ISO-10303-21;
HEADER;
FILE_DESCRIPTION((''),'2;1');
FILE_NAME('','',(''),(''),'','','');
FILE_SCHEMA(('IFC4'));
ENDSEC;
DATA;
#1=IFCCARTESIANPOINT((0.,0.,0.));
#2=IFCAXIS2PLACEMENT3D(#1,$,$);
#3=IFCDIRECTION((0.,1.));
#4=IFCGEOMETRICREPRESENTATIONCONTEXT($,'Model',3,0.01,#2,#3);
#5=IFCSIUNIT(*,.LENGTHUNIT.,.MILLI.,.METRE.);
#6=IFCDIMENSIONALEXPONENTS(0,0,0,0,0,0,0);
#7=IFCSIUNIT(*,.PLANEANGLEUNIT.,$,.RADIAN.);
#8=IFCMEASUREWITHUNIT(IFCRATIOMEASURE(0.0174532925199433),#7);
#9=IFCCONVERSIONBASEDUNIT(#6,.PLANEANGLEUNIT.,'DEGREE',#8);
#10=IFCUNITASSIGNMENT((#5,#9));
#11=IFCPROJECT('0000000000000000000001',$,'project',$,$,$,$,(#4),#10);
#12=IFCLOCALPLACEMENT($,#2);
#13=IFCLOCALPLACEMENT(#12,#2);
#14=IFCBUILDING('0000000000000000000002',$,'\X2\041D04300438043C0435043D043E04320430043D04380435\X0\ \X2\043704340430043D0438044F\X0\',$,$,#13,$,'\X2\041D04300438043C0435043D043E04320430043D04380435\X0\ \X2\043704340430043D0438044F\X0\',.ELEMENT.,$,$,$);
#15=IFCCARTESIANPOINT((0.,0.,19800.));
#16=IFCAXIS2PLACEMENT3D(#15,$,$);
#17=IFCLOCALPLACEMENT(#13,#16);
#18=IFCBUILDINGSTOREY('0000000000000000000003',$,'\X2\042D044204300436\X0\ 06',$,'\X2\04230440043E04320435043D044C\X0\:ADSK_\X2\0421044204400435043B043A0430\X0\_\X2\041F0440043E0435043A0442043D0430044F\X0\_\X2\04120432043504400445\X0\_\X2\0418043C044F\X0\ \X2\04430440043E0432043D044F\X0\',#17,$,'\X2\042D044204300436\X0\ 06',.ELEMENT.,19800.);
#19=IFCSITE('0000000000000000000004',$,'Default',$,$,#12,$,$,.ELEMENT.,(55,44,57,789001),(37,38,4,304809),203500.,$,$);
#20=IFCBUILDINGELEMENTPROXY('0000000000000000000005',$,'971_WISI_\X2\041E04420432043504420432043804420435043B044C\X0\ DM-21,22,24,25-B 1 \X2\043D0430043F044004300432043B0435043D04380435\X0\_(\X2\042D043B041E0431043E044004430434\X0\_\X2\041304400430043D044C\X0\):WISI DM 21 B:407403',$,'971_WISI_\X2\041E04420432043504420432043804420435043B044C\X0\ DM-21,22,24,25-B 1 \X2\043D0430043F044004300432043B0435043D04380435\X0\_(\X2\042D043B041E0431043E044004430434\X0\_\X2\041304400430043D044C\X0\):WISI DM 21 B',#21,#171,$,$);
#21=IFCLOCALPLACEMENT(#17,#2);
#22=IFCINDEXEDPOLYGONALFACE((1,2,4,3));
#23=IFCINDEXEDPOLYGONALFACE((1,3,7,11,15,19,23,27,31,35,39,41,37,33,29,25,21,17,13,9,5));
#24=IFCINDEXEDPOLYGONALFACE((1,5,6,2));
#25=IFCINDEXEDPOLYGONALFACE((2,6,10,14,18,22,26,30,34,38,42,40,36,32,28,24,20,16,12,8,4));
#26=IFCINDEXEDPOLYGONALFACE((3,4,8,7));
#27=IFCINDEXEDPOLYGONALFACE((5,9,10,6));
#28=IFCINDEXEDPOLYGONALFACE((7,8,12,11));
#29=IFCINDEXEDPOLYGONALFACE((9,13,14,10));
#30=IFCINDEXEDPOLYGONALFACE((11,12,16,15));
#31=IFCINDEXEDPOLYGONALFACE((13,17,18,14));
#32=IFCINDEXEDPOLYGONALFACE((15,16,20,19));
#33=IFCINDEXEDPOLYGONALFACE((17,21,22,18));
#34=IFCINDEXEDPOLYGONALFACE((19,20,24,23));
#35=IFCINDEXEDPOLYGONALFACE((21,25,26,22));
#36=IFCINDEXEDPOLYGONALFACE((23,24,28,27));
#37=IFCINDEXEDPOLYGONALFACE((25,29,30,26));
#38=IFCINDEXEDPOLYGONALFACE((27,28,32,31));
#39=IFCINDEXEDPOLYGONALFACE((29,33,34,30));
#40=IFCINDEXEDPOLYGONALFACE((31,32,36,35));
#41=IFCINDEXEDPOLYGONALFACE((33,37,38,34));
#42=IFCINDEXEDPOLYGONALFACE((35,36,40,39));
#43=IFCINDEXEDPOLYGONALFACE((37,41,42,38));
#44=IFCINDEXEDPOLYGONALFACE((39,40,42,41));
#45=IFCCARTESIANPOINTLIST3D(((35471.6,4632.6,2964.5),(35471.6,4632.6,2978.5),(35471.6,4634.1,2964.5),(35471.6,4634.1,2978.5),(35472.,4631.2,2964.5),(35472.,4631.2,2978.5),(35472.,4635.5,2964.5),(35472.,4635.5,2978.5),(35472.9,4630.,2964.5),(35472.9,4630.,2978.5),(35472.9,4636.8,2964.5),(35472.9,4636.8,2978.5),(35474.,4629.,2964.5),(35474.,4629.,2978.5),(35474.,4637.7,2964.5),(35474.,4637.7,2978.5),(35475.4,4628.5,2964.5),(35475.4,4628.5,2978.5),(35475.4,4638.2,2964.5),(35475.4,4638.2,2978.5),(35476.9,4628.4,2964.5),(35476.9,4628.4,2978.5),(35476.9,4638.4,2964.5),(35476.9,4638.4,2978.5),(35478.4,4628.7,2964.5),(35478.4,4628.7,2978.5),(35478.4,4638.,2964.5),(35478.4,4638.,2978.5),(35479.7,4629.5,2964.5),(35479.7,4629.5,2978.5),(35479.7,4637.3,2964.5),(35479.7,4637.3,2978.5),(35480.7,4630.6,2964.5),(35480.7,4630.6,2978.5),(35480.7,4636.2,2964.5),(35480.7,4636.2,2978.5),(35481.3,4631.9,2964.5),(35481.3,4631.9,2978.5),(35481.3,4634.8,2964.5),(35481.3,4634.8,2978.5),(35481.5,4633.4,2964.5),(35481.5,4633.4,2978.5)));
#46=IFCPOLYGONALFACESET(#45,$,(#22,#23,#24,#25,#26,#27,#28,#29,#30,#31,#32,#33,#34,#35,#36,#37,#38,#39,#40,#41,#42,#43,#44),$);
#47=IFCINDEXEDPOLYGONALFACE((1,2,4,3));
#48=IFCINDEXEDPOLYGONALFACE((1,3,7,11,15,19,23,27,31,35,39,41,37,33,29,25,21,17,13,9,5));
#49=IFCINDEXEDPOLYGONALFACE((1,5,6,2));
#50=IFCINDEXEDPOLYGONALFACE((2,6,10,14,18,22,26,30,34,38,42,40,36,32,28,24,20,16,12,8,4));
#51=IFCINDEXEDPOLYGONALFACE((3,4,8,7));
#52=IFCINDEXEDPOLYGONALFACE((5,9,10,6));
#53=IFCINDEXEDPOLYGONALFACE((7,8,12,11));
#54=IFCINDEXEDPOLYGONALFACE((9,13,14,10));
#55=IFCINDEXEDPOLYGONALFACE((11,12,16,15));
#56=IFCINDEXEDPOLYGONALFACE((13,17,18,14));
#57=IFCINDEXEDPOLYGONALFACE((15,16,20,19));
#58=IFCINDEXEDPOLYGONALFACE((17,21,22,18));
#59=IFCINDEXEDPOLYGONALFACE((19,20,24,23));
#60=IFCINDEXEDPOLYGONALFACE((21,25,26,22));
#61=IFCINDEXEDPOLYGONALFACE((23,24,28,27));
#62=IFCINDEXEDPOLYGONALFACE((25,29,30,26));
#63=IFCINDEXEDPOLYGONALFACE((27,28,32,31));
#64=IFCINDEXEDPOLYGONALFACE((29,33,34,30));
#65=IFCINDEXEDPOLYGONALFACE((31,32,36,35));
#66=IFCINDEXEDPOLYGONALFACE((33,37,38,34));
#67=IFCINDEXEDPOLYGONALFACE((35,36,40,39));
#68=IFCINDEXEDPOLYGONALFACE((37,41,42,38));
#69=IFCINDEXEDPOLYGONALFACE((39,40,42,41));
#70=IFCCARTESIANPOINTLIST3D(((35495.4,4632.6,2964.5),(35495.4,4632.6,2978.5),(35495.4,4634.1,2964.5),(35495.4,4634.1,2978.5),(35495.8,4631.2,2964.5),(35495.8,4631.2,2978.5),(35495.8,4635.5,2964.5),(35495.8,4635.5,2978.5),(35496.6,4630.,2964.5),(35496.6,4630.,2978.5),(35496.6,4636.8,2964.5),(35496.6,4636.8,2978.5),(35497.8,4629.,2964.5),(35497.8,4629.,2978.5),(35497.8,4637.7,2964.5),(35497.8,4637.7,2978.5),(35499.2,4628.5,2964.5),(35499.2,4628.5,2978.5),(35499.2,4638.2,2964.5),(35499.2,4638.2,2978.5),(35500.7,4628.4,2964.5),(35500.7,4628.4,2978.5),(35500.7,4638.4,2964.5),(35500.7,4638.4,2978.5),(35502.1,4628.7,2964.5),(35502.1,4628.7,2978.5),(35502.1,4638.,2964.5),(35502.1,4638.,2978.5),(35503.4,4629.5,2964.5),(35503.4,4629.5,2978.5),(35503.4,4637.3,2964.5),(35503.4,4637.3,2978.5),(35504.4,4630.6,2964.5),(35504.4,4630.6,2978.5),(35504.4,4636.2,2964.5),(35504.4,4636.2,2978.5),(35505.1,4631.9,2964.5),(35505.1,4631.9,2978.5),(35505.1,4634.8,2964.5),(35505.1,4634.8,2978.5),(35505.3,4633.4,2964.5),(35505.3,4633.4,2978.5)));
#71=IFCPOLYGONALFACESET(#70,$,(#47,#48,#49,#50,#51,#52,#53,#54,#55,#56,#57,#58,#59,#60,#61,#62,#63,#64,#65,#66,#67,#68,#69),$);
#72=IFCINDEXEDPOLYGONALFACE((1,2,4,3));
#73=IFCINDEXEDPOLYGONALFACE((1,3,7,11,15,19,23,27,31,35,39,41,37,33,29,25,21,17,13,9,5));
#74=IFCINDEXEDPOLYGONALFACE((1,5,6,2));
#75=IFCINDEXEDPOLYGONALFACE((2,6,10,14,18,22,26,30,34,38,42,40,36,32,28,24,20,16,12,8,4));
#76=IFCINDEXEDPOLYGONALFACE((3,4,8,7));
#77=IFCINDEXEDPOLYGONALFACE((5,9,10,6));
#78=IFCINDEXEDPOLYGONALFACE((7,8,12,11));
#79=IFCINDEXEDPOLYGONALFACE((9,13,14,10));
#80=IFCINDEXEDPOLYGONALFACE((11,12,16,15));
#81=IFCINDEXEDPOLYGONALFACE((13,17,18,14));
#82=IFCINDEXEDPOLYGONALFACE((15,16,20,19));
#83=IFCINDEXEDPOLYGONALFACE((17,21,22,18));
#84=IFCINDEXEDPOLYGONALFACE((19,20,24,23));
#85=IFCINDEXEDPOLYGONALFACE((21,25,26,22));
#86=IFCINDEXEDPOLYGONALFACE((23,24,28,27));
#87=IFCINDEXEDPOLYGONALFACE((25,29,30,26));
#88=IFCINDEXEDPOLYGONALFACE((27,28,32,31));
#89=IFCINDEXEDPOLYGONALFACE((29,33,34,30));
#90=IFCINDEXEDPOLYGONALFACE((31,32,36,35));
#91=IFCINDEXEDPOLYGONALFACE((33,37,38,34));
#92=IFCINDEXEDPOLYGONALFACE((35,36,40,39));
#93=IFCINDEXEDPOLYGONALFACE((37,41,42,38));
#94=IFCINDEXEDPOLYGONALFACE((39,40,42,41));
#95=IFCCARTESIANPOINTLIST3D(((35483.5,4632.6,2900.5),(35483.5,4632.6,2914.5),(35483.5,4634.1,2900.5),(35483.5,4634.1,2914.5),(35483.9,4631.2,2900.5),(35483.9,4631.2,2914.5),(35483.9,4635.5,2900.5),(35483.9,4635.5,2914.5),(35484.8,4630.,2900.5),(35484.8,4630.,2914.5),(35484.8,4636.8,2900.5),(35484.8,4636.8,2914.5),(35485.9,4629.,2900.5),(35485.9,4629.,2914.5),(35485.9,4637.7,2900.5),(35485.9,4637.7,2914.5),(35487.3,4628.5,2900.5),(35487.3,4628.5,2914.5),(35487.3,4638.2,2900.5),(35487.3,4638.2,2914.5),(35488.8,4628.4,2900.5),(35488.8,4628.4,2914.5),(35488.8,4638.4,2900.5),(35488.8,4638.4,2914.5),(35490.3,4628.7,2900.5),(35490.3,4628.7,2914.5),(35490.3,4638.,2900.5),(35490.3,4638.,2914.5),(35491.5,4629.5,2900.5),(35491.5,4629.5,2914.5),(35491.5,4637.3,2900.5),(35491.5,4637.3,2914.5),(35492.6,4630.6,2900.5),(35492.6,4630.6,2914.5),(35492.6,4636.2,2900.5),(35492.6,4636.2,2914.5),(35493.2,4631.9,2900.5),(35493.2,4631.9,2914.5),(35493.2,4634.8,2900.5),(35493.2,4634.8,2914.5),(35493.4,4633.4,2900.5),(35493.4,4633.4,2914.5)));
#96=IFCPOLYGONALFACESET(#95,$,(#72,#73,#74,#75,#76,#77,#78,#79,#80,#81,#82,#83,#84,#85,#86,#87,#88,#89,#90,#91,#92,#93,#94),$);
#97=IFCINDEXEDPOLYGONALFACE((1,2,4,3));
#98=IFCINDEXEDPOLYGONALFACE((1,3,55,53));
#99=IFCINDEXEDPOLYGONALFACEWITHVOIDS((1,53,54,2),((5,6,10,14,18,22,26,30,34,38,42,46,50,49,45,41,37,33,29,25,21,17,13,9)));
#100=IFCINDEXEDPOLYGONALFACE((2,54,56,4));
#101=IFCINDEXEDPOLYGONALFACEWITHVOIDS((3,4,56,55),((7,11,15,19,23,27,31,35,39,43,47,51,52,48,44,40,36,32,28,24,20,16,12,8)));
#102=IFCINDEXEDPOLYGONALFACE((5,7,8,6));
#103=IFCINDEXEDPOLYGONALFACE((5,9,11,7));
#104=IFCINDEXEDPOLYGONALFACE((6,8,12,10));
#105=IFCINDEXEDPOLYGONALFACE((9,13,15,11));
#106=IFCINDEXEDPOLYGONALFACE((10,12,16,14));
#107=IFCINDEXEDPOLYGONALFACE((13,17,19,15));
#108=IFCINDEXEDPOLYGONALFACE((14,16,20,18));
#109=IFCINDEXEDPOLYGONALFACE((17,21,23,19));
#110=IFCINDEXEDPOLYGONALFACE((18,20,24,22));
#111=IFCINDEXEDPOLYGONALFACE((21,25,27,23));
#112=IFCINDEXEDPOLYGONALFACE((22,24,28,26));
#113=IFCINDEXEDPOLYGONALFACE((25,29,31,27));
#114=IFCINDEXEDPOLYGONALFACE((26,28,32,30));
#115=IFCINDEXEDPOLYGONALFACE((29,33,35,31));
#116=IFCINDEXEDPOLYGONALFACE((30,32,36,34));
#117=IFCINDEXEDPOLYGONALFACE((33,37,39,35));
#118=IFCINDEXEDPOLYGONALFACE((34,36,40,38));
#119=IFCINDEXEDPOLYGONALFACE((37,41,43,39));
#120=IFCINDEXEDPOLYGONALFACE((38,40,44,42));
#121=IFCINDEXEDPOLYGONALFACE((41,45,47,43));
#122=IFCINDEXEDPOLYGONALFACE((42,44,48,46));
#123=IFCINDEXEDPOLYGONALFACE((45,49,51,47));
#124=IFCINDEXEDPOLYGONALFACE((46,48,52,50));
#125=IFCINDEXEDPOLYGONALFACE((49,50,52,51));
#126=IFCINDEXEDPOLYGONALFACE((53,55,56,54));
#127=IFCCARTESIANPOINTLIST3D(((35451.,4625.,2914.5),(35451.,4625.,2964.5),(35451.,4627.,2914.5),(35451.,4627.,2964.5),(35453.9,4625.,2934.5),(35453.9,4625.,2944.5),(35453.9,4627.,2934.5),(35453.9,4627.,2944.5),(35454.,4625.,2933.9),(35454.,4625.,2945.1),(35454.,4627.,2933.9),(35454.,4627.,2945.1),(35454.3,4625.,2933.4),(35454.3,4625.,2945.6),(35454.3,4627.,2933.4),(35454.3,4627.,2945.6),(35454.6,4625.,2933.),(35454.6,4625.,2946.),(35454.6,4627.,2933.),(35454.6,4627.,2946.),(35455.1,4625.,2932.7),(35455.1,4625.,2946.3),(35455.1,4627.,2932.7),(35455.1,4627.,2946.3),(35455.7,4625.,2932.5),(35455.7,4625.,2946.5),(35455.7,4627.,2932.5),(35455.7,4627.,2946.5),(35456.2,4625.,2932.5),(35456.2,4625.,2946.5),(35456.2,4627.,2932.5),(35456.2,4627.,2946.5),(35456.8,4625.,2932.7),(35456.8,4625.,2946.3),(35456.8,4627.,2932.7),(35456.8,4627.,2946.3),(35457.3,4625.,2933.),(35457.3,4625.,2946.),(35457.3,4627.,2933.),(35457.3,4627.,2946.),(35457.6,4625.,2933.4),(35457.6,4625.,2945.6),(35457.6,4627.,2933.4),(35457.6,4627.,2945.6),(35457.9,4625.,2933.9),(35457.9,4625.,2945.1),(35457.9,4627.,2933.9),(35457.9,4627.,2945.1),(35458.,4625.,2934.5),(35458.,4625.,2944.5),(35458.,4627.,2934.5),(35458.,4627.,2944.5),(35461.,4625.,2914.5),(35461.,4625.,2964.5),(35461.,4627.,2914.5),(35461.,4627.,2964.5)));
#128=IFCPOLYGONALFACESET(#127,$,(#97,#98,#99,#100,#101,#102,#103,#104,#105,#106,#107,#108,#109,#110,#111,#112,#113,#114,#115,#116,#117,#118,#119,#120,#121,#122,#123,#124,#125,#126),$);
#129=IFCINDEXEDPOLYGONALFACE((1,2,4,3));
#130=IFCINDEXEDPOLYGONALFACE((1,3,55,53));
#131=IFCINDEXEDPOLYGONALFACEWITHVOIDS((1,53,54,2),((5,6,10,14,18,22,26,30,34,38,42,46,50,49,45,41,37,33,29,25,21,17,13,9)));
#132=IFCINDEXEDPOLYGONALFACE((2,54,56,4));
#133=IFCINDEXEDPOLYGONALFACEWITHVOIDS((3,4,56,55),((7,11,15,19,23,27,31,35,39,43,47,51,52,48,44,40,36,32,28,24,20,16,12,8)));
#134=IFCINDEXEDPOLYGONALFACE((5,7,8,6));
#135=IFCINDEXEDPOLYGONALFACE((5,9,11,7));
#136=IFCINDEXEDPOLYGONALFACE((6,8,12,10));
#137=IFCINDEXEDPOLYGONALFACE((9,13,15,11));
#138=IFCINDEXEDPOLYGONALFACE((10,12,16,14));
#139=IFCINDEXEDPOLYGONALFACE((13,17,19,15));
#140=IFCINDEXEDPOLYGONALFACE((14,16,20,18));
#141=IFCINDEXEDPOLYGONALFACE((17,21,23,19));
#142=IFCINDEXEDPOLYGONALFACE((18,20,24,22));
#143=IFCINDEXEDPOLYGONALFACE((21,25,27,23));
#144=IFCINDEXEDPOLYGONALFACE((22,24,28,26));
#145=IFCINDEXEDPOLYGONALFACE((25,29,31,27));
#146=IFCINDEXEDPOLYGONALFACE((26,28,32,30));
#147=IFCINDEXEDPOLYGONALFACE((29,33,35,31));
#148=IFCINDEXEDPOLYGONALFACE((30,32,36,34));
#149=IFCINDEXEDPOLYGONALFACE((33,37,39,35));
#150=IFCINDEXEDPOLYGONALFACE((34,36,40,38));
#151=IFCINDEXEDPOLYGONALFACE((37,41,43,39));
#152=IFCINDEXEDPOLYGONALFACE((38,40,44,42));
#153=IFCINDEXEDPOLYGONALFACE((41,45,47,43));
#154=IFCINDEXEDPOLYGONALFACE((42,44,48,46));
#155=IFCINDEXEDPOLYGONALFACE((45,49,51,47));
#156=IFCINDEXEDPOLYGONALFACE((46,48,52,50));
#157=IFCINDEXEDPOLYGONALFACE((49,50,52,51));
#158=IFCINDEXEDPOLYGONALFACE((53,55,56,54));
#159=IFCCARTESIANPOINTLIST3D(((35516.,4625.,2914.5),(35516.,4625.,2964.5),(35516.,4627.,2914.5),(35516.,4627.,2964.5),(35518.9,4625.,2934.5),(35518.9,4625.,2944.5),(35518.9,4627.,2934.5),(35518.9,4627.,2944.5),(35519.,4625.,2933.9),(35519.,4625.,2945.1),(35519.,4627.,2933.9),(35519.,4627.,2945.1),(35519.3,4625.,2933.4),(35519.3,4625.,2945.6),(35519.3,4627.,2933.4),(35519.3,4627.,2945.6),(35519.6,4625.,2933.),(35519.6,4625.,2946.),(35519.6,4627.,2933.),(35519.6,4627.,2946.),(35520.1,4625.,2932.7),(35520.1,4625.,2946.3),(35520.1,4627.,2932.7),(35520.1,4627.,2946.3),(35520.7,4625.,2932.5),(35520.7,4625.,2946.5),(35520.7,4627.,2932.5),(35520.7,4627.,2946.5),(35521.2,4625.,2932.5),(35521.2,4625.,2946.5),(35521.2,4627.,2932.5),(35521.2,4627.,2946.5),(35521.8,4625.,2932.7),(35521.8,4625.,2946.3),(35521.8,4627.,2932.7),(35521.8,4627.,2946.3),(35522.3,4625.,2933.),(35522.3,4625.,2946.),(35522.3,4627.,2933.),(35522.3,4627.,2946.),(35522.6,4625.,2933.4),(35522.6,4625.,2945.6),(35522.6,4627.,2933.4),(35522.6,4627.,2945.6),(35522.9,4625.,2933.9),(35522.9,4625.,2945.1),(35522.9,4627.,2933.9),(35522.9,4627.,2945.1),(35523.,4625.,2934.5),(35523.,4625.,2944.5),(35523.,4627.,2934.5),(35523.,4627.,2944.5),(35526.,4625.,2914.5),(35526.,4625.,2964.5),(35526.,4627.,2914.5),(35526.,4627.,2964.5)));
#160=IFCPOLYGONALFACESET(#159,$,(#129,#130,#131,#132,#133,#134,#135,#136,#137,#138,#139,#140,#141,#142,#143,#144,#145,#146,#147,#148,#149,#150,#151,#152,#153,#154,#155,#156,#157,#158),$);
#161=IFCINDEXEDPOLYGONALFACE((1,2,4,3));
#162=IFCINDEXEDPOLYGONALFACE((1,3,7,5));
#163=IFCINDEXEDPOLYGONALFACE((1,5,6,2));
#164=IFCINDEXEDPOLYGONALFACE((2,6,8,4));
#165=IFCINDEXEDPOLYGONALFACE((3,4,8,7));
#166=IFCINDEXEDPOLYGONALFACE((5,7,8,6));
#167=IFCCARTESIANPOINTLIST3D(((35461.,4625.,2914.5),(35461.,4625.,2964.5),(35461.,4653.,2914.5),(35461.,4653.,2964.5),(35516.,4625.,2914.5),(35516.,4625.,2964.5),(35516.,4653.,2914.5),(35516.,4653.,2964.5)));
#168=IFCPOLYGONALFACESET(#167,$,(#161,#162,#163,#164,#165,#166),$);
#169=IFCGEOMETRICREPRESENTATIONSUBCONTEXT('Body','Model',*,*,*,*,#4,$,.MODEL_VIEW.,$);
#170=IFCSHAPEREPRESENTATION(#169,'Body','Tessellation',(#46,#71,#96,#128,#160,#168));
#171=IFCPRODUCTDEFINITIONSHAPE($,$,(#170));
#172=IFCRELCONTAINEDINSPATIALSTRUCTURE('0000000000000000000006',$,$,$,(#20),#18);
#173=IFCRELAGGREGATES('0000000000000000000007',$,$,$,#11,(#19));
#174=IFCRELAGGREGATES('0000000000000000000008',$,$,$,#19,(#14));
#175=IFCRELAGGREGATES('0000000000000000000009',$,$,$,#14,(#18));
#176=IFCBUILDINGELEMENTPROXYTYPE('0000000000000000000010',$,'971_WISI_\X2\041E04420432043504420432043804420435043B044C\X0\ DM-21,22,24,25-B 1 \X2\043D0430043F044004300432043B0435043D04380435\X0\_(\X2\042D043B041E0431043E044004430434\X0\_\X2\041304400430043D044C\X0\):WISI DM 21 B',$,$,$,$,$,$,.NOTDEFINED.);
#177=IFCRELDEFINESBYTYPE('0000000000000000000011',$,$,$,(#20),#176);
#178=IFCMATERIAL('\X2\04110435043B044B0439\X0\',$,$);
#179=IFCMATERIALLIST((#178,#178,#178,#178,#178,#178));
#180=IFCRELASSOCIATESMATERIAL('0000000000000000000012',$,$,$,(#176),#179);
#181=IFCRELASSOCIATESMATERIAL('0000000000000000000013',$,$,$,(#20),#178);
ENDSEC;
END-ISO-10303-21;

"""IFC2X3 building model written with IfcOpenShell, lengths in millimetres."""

from ifc_helpers import new_model, entity, si_unit, converted_unit, direction, frame, frame_2d, origin, place, context, subcontext, project, spatial, polyline, circle_curve, parameter, trimmed, segment, composite_curve, rectangle, circle, outline, extrude, source, transform, mapped, material, material_list, type_object, type_shapes, element, save


model = new_model("IFC2X3")

# Units and contexts
model_context = context("Model", 3, precision=0.01, world=origin(), true_north=direction((0.0, 1.0)))
body_context = subcontext(model_context, "Body", "Model", "MODEL_VIEW")
ifc_project = project(units=[si_unit("LENGTHUNIT", "METRE", prefix="MILLI"), converted_unit("PLANEANGLEUNIT", "DEGREE", entity("IfcRatioMeasure", 0.0174532925199433), si_unit("PLANEANGLEUNIT", "RADIAN"), dimensions=[0, 0, 0, 0, 0, 0, 0])], contexts=[model_context])

# Site, building, storey
site_placement = place(None, frame((0.0, 0.0, 0.0)))
site = spatial("IfcSite", under=ifc_project, at=site_placement, Name="Default", CompositionType="ELEMENT", RefLatitude=(55, 44, 57, 789001), RefLongitude=(37, 38, 4, 304809), RefElevation=203500.0)
building_placement = place(site_placement, origin())
building = spatial("IfcBuilding", under=site, at=building_placement, Name="Наименование здания", LongName="Наименование здания", CompositionType="ELEMENT")
storey_placement = place(building_placement, frame((0.0, 0.0, 19800.0)))
storey = spatial("IfcBuildingStorey", under=building, at=storey_placement, Name="Этаж 06", ObjectType="Уровень:ADSK_Стрелка_Проектная_Вверх_Имя уровня", LongName="Этаж 06", CompositionType="ELEMENT", Elevation=19800.0)

# Building element proxy
ifc_material_1 = material(Name="Белый")
ifc_material_list_1 = material_list([ifc_material_1, ifc_material_1, ifc_material_1, ifc_material_1, ifc_material_1, ifc_material_1])
building_element_proxy_type_1 = type_object("IfcBuildingElementProxyType", Name="971_WISI_Ответвитель DM-21,22,24,25-B 1 направление_(ЭлОборуд_Грань):WISI DM 21 B", PredefinedType="NOTDEFINED", material=ifc_material_list_1)
shared_shape_1 = source(origin(), body_context, "Body", "SweptSolid", [
    extrude(circle(Radius=5.0, at=frame_2d((0.0, 0.0), x_axis=(1.0, 0.0))), frame((11.9, 25.0, 8.4), z_axis=(0.0, 1.0, 0.0), x_axis=(-1.0, 0.0, 0.0)), (0.0, 0.0, 1.0), 14.0),
    extrude(circle(Radius=5.0, at=frame_2d((0.0, 0.0), x_axis=(1.0, 0.0))), frame((-11.8, 25.0, 8.4), z_axis=(0.0, 1.0, 0.0), x_axis=(-1.0, 0.0, 0.0)), (0.0, 0.0, 1.0), 14.0),
    extrude(circle(Radius=5.0, at=frame_2d((0.0, 0.0), x_axis=(1.0, 0.0))), frame((0.0, -39.0, 8.4), z_axis=(0.0, 1.0, 0.0), x_axis=(-1.0, 0.0, 0.0)), (0.0, 0.0, 1.0), 14.0),
    extrude(outline(polyline([(-5.0, -25.0), (5.0, -25.0), (5.0, 25.0), (-5.0, 25.0), (-5.0, -25.0)]), holes=[composite_curve([segment(polyline([(2.0, 5.0), (2.0, -5.0)]), True, "CONTINUOUS"), segment(trimmed(circle_curve(frame_2d((0.0, -5.0), x_axis=(-1.0, 0.0)), 2.0), [parameter(0.0)], [parameter(180.0)], True, "PARAMETER"), False, "CONTINUOUS"), segment(polyline([(-2.0, -5.0), (-2.0, 5.0)]), True, "CONTINUOUS"), segment(trimmed(circle_curve(frame_2d((0.0, 5.0), x_axis=(-1.0, 0.0)), 2.0), [parameter(180.0)], [parameter(0.0)], True, "PARAMETER"), False, "CONTINUOUS")], self_intersect=False)]), frame((32.5, 0.0, 0.0), z_axis=(0.0, 0.0, 1.0), x_axis=(-1.0, 0.0, 0.0)), (0.0, 0.0, 1.0), 2.0),
    extrude(outline(polyline([(-5.0, -25.0), (5.0, -25.0), (5.0, 25.0), (-5.0, 25.0), (-5.0, -25.0)]), holes=[composite_curve([segment(polyline([(-2.0, -5.0), (-2.0, 5.0)]), True, "CONTINUOUS"), segment(trimmed(circle_curve(frame_2d((0.0, 5.0), x_axis=(-1.0, 0.0)), 2.0), [parameter(180.0)], [parameter(0.0)], True, "PARAMETER"), False, "CONTINUOUS"), segment(polyline([(2.0, 5.0), (2.0, -5.0)]), True, "CONTINUOUS"), segment(trimmed(circle_curve(frame_2d((0.0, -5.0), x_axis=(-1.0, 0.0)), 2.0), [parameter(0.0)], [parameter(180.0)], True, "PARAMETER"), False, "CONTINUOUS")], self_intersect=False)]), frame((-32.5, 0.0, 0.0), z_axis=(0.0, 0.0, 1.0), x_axis=(-1.0, 0.0, 0.0)), (0.0, 0.0, 1.0), 2.0),
    extrude(rectangle(XDim=55.0, YDim=50.0, at=frame_2d((0.0, 0.0), x_axis=(1.0, 0.0))), frame((0.0, 0.0, 0.0), z_axis=(0.0, 0.0, 1.0), x_axis=(-1.0, 0.0, 0.0)), (0.0, 0.0, 1.0), 28.0),
])
type_shapes(building_element_proxy_type_1, [shared_shape_1])
for number, where, z_axis, x_axis, name in (
    (1, (35488.5, 4625.0, 2939.5), (0.0, 1.0, 0.0), (-1.0, 0.0, 0.0), "971_WISI_Ответвитель DM-21,22,24,25-B 1 направление_(ЭлОборуд_Грань):WISI DM 21 B:407403"),
):
    element("IfcBuildingElementProxy", number, at=place(storey_placement, frame(where, z_axis=z_axis, x_axis=x_axis)), inside=storey, type_object=building_element_proxy_type_1, material=ifc_material_1, Name=name, ObjectType="971_WISI_Ответвитель DM-21,22,24,25-B 1 направление_(ЭлОборуд_Грань):WISI DM 21 B", context=body_context, shape_type="MappedRepresentation", body=[
        mapped(shared_shape_1, transform((0.0, 0.0, 0.0), scale=1.0)),
    ])

save(model, "model.ifc")
